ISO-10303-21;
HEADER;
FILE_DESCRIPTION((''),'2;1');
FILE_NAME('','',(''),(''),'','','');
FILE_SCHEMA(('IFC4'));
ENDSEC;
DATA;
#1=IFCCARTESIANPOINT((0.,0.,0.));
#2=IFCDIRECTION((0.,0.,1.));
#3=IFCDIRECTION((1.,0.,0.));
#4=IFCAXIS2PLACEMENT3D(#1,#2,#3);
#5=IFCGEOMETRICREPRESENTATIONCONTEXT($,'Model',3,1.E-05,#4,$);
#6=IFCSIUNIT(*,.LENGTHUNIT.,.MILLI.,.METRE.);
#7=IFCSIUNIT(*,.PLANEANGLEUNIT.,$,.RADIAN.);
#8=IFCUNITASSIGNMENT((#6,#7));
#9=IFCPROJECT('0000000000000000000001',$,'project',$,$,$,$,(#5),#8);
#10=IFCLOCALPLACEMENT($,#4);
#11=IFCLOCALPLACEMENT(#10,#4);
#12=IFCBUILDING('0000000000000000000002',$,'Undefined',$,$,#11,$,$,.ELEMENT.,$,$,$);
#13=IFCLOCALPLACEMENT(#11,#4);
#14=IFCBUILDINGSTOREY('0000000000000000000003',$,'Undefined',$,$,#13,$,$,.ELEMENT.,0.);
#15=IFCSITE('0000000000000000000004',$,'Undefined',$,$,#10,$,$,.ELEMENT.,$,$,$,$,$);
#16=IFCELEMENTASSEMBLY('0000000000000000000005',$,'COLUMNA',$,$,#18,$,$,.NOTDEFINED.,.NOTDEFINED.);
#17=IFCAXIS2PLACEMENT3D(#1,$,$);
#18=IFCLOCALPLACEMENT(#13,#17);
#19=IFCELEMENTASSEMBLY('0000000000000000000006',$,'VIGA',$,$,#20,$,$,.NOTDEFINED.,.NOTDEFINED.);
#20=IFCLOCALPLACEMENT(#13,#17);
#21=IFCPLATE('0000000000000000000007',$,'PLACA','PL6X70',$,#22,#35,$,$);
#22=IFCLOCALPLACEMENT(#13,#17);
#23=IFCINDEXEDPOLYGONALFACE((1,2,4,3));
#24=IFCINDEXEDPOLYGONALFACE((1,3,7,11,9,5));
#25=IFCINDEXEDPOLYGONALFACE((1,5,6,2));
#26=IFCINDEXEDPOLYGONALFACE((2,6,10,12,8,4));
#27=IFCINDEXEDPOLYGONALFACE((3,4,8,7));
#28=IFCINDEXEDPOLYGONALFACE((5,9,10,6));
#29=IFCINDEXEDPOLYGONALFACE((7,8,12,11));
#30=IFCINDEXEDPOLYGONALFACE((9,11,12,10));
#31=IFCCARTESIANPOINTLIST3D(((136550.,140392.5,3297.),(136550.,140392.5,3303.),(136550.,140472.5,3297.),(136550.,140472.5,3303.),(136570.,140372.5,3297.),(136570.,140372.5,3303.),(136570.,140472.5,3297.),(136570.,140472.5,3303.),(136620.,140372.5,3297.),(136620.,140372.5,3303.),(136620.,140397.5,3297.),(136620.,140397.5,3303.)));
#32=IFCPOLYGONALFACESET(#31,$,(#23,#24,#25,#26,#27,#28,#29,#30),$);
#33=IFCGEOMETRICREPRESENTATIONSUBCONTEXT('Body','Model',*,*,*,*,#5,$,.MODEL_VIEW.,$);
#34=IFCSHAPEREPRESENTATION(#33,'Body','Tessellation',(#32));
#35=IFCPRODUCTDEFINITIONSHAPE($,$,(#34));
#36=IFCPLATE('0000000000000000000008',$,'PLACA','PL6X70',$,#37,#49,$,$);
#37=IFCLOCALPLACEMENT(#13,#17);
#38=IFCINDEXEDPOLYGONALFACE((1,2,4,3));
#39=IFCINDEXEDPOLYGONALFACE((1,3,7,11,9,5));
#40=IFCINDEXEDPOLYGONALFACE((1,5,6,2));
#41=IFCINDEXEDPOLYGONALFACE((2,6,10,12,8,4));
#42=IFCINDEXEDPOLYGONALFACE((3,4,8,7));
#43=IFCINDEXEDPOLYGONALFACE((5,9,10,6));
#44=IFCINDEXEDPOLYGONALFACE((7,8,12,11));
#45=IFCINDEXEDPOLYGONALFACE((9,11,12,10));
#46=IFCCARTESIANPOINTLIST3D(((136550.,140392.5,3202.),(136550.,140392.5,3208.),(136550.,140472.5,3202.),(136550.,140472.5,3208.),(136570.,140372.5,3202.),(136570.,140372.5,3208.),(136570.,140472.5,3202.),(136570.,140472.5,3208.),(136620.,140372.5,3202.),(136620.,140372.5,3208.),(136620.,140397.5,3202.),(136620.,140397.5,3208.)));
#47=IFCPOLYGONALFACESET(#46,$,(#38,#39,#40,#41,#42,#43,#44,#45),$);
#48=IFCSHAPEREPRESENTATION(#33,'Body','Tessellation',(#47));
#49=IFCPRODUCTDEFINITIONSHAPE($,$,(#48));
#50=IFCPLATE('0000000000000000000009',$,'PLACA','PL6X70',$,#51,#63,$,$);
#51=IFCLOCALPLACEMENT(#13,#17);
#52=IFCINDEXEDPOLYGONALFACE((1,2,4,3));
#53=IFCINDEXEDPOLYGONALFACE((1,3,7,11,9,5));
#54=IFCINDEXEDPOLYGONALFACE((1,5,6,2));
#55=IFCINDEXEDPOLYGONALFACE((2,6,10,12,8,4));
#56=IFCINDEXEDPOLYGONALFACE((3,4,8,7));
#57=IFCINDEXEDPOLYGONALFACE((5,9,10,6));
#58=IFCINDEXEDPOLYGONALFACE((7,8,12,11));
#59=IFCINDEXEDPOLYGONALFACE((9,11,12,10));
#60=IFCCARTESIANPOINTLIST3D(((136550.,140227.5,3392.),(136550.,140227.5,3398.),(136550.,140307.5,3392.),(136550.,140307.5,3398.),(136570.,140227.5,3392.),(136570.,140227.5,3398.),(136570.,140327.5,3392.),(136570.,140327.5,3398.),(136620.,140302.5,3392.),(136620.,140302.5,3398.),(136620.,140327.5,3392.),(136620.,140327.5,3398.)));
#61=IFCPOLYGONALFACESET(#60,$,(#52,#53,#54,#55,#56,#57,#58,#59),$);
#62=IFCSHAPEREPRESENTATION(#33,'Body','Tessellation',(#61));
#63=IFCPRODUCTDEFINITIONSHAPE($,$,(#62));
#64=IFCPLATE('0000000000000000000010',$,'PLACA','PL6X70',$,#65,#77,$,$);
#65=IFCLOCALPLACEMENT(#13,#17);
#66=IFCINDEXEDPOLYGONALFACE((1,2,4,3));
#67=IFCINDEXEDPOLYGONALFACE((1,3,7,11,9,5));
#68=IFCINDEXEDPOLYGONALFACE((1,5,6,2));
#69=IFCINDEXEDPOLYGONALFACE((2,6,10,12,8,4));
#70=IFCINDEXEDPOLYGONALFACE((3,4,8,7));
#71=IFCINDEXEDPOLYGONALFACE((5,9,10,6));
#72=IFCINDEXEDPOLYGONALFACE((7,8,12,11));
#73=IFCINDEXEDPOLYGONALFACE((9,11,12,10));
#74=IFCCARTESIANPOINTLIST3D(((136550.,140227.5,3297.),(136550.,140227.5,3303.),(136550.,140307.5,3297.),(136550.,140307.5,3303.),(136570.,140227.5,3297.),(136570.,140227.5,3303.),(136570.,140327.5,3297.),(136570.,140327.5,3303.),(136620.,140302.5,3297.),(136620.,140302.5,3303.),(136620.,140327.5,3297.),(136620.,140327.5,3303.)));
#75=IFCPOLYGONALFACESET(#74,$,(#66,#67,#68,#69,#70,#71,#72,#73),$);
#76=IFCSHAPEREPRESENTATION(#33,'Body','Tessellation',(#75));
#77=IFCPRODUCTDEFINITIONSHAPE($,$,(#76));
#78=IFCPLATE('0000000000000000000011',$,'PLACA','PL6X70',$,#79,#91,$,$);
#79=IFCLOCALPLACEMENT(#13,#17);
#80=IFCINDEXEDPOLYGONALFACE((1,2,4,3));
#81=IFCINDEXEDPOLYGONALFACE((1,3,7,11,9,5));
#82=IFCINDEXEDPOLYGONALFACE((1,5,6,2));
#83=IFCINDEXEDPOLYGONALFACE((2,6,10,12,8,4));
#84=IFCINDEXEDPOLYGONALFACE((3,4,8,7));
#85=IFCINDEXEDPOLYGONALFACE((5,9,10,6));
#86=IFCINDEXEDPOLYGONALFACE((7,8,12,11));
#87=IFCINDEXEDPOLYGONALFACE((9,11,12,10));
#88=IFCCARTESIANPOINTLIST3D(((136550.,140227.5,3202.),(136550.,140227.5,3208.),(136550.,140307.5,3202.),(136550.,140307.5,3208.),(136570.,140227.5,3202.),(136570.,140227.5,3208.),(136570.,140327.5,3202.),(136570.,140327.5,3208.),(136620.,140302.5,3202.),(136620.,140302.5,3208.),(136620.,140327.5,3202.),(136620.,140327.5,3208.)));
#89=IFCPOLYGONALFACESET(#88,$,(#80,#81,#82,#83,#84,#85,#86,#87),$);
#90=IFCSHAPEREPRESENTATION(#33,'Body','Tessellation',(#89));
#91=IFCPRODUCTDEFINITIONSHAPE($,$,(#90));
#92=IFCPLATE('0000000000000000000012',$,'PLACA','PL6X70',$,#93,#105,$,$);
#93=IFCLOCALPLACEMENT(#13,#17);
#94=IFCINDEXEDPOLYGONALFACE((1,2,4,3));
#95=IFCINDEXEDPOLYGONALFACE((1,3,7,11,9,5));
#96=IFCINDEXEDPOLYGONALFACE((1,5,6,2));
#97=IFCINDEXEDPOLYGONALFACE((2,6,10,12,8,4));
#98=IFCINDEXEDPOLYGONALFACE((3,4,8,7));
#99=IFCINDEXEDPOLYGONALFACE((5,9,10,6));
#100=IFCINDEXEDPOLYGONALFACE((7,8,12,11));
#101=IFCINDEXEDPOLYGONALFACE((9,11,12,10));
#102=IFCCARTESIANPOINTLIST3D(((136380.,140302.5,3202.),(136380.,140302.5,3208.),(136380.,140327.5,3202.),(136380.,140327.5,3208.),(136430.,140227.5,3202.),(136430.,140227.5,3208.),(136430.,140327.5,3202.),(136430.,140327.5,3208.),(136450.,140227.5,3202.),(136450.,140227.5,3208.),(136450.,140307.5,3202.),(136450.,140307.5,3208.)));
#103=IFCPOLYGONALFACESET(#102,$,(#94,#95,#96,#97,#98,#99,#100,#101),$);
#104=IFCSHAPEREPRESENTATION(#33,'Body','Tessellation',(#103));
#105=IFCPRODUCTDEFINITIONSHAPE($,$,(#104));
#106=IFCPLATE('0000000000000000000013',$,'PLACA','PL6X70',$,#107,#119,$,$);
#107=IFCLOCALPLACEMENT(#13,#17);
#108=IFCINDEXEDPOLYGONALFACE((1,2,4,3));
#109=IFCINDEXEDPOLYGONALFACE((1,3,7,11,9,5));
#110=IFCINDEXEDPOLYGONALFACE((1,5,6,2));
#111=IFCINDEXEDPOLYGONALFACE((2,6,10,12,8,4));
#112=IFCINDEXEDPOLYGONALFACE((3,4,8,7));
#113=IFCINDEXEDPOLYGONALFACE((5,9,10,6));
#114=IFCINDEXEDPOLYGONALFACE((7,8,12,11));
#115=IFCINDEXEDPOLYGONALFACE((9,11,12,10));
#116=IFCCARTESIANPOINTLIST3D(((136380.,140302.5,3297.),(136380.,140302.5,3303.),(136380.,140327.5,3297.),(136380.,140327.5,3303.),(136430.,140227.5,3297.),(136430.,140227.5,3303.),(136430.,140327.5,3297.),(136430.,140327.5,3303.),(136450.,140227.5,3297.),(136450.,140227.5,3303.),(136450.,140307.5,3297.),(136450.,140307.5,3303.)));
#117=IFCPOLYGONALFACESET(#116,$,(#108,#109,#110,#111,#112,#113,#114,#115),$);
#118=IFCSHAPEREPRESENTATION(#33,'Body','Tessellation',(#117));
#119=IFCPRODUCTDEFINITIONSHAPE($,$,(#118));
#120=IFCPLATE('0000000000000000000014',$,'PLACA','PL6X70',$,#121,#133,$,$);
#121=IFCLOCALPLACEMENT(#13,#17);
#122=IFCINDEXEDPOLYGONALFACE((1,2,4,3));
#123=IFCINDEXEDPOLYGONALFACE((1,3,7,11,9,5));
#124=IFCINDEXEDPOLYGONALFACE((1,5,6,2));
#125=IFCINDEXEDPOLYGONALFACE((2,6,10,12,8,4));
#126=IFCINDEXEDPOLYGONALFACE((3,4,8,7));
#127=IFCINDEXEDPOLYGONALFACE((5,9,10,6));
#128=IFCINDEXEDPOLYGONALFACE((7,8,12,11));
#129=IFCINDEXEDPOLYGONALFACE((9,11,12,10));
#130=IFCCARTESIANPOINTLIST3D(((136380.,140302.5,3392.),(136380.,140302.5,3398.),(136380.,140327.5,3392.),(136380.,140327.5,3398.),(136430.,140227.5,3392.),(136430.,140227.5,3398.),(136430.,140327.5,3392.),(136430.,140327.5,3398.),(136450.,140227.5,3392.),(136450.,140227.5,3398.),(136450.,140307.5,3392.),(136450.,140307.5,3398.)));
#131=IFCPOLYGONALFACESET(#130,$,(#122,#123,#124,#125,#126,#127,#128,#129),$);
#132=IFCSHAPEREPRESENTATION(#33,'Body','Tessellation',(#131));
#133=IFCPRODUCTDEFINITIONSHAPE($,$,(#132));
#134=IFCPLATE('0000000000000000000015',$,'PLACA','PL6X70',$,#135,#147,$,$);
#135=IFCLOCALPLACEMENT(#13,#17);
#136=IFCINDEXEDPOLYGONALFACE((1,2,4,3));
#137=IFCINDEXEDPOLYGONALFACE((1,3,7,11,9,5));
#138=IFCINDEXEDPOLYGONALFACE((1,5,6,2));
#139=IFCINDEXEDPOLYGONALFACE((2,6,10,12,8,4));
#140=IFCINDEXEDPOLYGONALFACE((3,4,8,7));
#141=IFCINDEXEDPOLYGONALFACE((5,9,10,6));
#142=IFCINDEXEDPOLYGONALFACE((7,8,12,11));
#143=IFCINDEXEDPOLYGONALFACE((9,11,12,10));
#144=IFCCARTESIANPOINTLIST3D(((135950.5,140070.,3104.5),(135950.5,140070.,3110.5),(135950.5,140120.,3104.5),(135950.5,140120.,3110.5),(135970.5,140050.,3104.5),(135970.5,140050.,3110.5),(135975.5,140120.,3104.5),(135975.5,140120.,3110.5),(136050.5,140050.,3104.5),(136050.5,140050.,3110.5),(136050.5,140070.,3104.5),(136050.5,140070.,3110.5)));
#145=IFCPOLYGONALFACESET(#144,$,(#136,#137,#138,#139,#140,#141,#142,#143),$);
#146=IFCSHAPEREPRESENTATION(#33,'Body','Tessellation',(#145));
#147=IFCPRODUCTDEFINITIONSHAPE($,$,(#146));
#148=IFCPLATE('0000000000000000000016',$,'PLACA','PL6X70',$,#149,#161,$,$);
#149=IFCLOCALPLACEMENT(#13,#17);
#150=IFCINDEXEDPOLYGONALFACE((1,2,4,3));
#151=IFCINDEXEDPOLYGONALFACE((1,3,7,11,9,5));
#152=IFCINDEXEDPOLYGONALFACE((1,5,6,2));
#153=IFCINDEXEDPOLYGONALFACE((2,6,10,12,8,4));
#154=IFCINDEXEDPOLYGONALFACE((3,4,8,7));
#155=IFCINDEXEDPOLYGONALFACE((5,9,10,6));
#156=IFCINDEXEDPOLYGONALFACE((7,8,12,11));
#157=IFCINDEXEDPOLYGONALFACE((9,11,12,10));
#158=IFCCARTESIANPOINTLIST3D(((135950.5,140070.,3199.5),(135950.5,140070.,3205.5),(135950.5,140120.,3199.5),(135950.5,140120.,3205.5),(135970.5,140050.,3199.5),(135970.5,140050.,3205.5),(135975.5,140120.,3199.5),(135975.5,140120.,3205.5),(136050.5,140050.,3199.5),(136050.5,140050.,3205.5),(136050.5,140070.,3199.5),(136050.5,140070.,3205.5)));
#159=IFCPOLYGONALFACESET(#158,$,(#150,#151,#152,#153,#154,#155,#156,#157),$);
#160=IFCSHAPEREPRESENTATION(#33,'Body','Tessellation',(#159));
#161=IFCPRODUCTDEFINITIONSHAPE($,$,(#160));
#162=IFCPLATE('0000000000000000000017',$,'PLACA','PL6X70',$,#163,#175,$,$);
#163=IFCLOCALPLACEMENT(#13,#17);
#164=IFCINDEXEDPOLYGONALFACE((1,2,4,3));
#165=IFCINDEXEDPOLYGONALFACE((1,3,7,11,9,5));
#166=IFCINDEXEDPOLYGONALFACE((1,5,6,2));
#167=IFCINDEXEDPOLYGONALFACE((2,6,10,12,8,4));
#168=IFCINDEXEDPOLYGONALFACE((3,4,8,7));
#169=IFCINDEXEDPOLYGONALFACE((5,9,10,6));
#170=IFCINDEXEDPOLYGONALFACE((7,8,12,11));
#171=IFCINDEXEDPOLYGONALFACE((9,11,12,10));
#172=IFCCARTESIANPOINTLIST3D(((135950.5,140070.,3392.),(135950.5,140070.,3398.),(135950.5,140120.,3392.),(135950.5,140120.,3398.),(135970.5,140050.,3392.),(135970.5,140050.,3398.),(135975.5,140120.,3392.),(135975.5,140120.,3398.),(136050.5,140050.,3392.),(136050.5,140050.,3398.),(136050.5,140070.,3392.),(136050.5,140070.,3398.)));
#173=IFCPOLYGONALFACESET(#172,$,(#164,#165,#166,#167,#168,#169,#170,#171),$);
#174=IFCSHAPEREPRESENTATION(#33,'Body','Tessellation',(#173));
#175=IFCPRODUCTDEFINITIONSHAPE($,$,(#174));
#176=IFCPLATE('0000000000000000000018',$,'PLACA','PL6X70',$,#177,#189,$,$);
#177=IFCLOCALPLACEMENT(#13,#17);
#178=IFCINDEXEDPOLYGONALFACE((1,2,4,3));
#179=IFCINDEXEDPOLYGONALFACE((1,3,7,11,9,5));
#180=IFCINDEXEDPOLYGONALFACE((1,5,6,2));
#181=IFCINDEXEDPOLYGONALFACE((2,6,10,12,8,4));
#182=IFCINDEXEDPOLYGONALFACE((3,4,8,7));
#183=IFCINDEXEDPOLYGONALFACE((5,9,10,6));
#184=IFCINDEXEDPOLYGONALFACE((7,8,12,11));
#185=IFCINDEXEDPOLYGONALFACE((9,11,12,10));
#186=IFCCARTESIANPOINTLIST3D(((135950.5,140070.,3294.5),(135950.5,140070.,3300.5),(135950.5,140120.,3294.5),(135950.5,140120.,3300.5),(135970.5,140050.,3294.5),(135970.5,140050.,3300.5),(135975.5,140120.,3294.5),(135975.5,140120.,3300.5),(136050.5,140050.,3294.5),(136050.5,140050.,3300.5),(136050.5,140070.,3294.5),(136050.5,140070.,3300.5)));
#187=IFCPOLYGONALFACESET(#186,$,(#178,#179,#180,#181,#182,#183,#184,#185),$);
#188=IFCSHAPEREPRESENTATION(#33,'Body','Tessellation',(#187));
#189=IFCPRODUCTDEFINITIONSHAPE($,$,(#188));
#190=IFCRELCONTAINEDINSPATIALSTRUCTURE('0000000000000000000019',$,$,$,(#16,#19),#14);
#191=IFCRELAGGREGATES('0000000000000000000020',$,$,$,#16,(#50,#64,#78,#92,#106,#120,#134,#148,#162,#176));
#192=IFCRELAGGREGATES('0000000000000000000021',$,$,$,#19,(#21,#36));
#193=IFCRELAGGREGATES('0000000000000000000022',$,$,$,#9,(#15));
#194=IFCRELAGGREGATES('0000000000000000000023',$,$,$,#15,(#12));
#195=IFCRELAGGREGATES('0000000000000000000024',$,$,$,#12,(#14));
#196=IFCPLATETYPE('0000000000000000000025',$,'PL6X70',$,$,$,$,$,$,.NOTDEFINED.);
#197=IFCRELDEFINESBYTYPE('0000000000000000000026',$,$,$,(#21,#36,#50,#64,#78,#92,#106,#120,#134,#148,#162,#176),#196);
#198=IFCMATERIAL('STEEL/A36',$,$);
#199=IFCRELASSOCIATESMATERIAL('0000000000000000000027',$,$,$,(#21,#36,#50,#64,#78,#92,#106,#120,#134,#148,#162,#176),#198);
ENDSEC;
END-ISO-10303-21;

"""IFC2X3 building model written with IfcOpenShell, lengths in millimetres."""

from ifc_helpers import new_model, si_unit, frame, origin_with_axes, place, context, subcontext, project, spatial, polyline, outline, extrude, material, type_object, element, aggregate, save


model = new_model("IFC2X3")

# Units and contexts
model_context = context("Model", 3, precision=1e-05, world=origin_with_axes())
body_context = subcontext(model_context, "Body", "Model", "MODEL_VIEW")
ifc_project = project(units=[si_unit("LENGTHUNIT", "METRE", prefix="MILLI"), si_unit("PLANEANGLEUNIT", "RADIAN")], contexts=[model_context])

# Site, building, storey
site_placement = place(None, origin_with_axes())
site = spatial("IfcSite", under=ifc_project, at=site_placement, Name="Undefined", CompositionType="ELEMENT")
building_placement = place(site_placement, origin_with_axes())
building = spatial("IfcBuilding", under=site, at=building_placement, Name="Undefined", CompositionType="ELEMENT")
storey_placement = place(building_placement, origin_with_axes())
storey = spatial("IfcBuildingStorey", under=building, at=storey_placement, Name="Undefined", CompositionType="ELEMENT", Elevation=0.0)

# Element assembly
assembly_1_placement = place(storey_placement, origin_with_axes())
assembly_1 = element("IfcElementAssembly", 1, at=assembly_1_placement, inside=storey, Name="COLUMNA", AssemblyPlace="NOTDEFINED", PredefinedType="NOTDEFINED")
ifc_material_1 = material(Name="STEEL/A36")

# Element assembly
assembly_2_placement = place(storey_placement, origin_with_axes())
assembly_2 = element("IfcElementAssembly", 2, at=assembly_2_placement, inside=storey, Name="VIGA", AssemblyPlace="NOTDEFINED", PredefinedType="NOTDEFINED")

# Plates
plate_type_1 = type_object("IfcPlateType", Name="PL6X70", PredefinedType="NOTDEFINED")
plate_1_placement = place(assembly_2_placement, frame((136620.0, 140372.5, 3300.0), z_axis=(0.0, 0.0, 1.0), x_axis=(0.0, 1.0, 0.0)))
plate_1 = element("IfcPlate", 3, at=plate_1_placement, type_object=plate_type_1, material=ifc_material_1, Name="PLACA", Description="PL6X70", context=body_context, shape_type="SweptSolid", body=[
    extrude(outline(polyline([(0.0, 0.0), (25.0, 0.0), (100.0, 50.0), (100.0, 70.0), (20.0, 70.0), (0.0, 50.0), (0.0, 0.0)])), frame((0.0, 0.0, -3.0), z_axis=(0.0, 0.0, 1.0), x_axis=(1.0, 0.0, 0.0)), (0.0, 0.0, 1.0), 6.0),
])
plate_2_placement = place(assembly_2_placement, frame((136620.0, 140372.5, 3205.0), z_axis=(0.0, 0.0, 1.0), x_axis=(0.0, 1.0, 0.0)))
plate_2 = element("IfcPlate", 4, at=plate_2_placement, type_object=plate_type_1, material=ifc_material_1, Name="PLACA", Description="PL6X70", context=body_context, shape_type="SweptSolid", body=[
    extrude(outline(polyline([(0.0, 0.0), (25.0, 0.0), (100.0, 50.0), (100.0, 70.0), (20.0, 70.0), (0.0, 50.0), (0.0, 0.0)])), frame((0.0, 0.0, -3.0), z_axis=(0.0, 0.0, 1.0), x_axis=(1.0, 0.0, 0.0)), (0.0, 0.0, 1.0), 6.0),
])
plate_3_placement = place(assembly_1_placement, frame((136620.0, 140327.5, 3395.0), z_axis=(0.0, 0.0, -1.0), x_axis=(0.0, -1.0, 0.0)))
plate_3 = element("IfcPlate", 5, at=plate_3_placement, type_object=plate_type_1, material=ifc_material_1, Name="PLACA", Description="PL6X70", context=body_context, shape_type="SweptSolid", body=[
    extrude(outline(polyline([(0.0, 0.0), (25.0, 0.0), (100.0, 50.0), (100.0, 70.0), (20.0, 70.0), (0.0, 50.0), (0.0, 0.0)])), frame((0.0, 0.0, -3.0), z_axis=(0.0, 0.0, 1.0), x_axis=(1.0, 0.0, 0.0)), (0.0, 0.0, 1.0), 6.0),
])
plate_4_placement = place(assembly_1_placement, frame((136620.0, 140327.5, 3300.0), z_axis=(0.0, 0.0, -1.0), x_axis=(0.0, -1.0, 0.0)))
plate_4 = element("IfcPlate", 6, at=plate_4_placement, type_object=plate_type_1, material=ifc_material_1, Name="PLACA", Description="PL6X70", context=body_context, shape_type="SweptSolid", body=[
    extrude(outline(polyline([(0.0, 0.0), (25.0, 0.0), (100.0, 50.0), (100.0, 70.0), (20.0, 70.0), (0.0, 50.0), (0.0, 0.0)])), frame((0.0, 0.0, -3.0), z_axis=(0.0, 0.0, 1.0), x_axis=(1.0, 0.0, 0.0)), (0.0, 0.0, 1.0), 6.0),
])
plate_5_placement = place(assembly_1_placement, frame((136620.0, 140327.5, 3205.0), z_axis=(0.0, 0.0, -1.0), x_axis=(0.0, -1.0, 0.0)))
plate_5 = element("IfcPlate", 7, at=plate_5_placement, type_object=plate_type_1, material=ifc_material_1, Name="PLACA", Description="PL6X70", context=body_context, shape_type="SweptSolid", body=[
    extrude(outline(polyline([(0.0, 0.0), (25.0, 0.0), (100.0, 50.0), (100.0, 70.0), (20.0, 70.0), (0.0, 50.0), (0.0, 0.0)])), frame((0.0, 0.0, -3.0), z_axis=(0.0, 0.0, 1.0), x_axis=(1.0, 0.0, 0.0)), (0.0, 0.0, 1.0), 6.0),
])
plate_6_placement = place(assembly_1_placement, frame((136380.0, 140327.5, 3205.0), z_axis=(0.0, 0.0, 1.0), x_axis=(0.0, -1.0, 0.0)))
plate_6 = element("IfcPlate", 8, at=plate_6_placement, type_object=plate_type_1, material=ifc_material_1, Name="PLACA", Description="PL6X70", context=body_context, shape_type="SweptSolid", body=[
    extrude(outline(polyline([(0.0, 0.0), (25.0, 0.0), (100.0, 50.0), (100.0, 70.0), (20.0, 70.0), (0.0, 50.0), (0.0, 0.0)])), frame((0.0, 0.0, -3.0), z_axis=(0.0, 0.0, 1.0), x_axis=(1.0, 0.0, 0.0)), (0.0, 0.0, 1.0), 6.0),
])
plate_7_placement = place(assembly_1_placement, frame((136380.0, 140327.5, 3300.0), z_axis=(0.0, 0.0, 1.0), x_axis=(0.0, -1.0, 0.0)))
plate_7 = element("IfcPlate", 9, at=plate_7_placement, type_object=plate_type_1, material=ifc_material_1, Name="PLACA", Description="PL6X70", context=body_context, shape_type="SweptSolid", body=[
    extrude(outline(polyline([(0.0, 0.0), (25.0, 0.0), (100.0, 50.0), (100.0, 70.0), (20.0, 70.0), (0.0, 50.0), (0.0, 0.0)])), frame((0.0, 0.0, -3.0), z_axis=(0.0, 0.0, 1.0), x_axis=(1.0, 0.0, 0.0)), (0.0, 0.0, 1.0), 6.0),
])
plate_8_placement = place(assembly_1_placement, frame((136380.0, 140327.5, 3395.0), z_axis=(0.0, 0.0, 1.0), x_axis=(0.0, -1.0, 0.0)))
plate_8 = element("IfcPlate", 10, at=plate_8_placement, type_object=plate_type_1, material=ifc_material_1, Name="PLACA", Description="PL6X70", context=body_context, shape_type="SweptSolid", body=[
    extrude(outline(polyline([(0.0, 0.0), (25.0, 0.0), (100.0, 50.0), (100.0, 70.0), (20.0, 70.0), (0.0, 50.0), (0.0, 0.0)])), frame((0.0, 0.0, -3.0), z_axis=(0.0, 0.0, 1.0), x_axis=(1.0, 0.0, 0.0)), (0.0, 0.0, 1.0), 6.0),
])
plate_9_placement = place(assembly_1_placement, frame((135950.5, 140120.0, 3107.5), z_axis=(0.0, 0.0, -1.0), x_axis=(1.0, 0.0, 0.0)))
plate_9 = element("IfcPlate", 11, at=plate_9_placement, type_object=plate_type_1, material=ifc_material_1, Name="PLACA", Description="PL6X70", context=body_context, shape_type="SweptSolid", body=[
    extrude(outline(polyline([(0.0, 0.0), (25.0, 0.0), (100.0, 50.0), (100.0, 70.0), (20.0, 70.0), (0.0, 50.0), (0.0, 0.0)])), frame((0.0, 0.0, -3.0), z_axis=(0.0, 0.0, 1.0), x_axis=(1.0, 0.0, 0.0)), (0.0, 0.0, 1.0), 6.0),
])
plate_10_placement = place(assembly_1_placement, frame((135950.5, 140120.0, 3202.5), z_axis=(0.0, 0.0, -1.0), x_axis=(1.0, 0.0, 0.0)))
plate_10 = element("IfcPlate", 12, at=plate_10_placement, type_object=plate_type_1, material=ifc_material_1, Name="PLACA", Description="PL6X70", context=body_context, shape_type="SweptSolid", body=[
    extrude(outline(polyline([(0.0, 0.0), (25.0, 0.0), (100.0, 50.0), (100.0, 70.0), (20.0, 70.0), (0.0, 50.0), (0.0, 0.0)])), frame((0.0, 0.0, -3.0), z_axis=(0.0, 0.0, 1.0), x_axis=(1.0, 0.0, 0.0)), (0.0, 0.0, 1.0), 6.0),
])
plate_11_placement = place(assembly_1_placement, frame((135950.5, 140120.0, 3395.0), z_axis=(0.0, 0.0, -1.0), x_axis=(1.0, 0.0, 0.0)))
plate_11 = element("IfcPlate", 13, at=plate_11_placement, type_object=plate_type_1, material=ifc_material_1, Name="PLACA", Description="PL6X70", context=body_context, shape_type="SweptSolid", body=[
    extrude(outline(polyline([(0.0, 0.0), (25.0, 0.0), (100.0, 50.0), (100.0, 70.0), (20.0, 70.0), (0.0, 50.0), (0.0, 0.0)])), frame((0.0, 0.0, -3.0), z_axis=(0.0, 0.0, 1.0), x_axis=(1.0, 0.0, 0.0)), (0.0, 0.0, 1.0), 6.0),
])
plate_12_placement = place(assembly_1_placement, frame((135950.5, 140120.0, 3297.5), z_axis=(0.0, 0.0, -1.0), x_axis=(1.0, 0.0, 0.0)))
plate_12 = element("IfcPlate", 14, at=plate_12_placement, type_object=plate_type_1, material=ifc_material_1, Name="PLACA", Description="PL6X70", context=body_context, shape_type="SweptSolid", body=[
    extrude(outline(polyline([(0.0, 0.0), (25.0, 0.0), (100.0, 50.0), (100.0, 70.0), (20.0, 70.0), (0.0, 50.0), (0.0, 0.0)])), frame((0.0, 0.0, -3.0), z_axis=(0.0, 0.0, 1.0), x_axis=(1.0, 0.0, 0.0)), (0.0, 0.0, 1.0), 6.0),
])

aggregate(assembly_1, [plate_3, plate_4, plate_5, plate_6, plate_7, plate_8, plate_9, plate_10, plate_11, plate_12])
aggregate(assembly_2, [plate_1, plate_2])

save(model, "model.ifc")
